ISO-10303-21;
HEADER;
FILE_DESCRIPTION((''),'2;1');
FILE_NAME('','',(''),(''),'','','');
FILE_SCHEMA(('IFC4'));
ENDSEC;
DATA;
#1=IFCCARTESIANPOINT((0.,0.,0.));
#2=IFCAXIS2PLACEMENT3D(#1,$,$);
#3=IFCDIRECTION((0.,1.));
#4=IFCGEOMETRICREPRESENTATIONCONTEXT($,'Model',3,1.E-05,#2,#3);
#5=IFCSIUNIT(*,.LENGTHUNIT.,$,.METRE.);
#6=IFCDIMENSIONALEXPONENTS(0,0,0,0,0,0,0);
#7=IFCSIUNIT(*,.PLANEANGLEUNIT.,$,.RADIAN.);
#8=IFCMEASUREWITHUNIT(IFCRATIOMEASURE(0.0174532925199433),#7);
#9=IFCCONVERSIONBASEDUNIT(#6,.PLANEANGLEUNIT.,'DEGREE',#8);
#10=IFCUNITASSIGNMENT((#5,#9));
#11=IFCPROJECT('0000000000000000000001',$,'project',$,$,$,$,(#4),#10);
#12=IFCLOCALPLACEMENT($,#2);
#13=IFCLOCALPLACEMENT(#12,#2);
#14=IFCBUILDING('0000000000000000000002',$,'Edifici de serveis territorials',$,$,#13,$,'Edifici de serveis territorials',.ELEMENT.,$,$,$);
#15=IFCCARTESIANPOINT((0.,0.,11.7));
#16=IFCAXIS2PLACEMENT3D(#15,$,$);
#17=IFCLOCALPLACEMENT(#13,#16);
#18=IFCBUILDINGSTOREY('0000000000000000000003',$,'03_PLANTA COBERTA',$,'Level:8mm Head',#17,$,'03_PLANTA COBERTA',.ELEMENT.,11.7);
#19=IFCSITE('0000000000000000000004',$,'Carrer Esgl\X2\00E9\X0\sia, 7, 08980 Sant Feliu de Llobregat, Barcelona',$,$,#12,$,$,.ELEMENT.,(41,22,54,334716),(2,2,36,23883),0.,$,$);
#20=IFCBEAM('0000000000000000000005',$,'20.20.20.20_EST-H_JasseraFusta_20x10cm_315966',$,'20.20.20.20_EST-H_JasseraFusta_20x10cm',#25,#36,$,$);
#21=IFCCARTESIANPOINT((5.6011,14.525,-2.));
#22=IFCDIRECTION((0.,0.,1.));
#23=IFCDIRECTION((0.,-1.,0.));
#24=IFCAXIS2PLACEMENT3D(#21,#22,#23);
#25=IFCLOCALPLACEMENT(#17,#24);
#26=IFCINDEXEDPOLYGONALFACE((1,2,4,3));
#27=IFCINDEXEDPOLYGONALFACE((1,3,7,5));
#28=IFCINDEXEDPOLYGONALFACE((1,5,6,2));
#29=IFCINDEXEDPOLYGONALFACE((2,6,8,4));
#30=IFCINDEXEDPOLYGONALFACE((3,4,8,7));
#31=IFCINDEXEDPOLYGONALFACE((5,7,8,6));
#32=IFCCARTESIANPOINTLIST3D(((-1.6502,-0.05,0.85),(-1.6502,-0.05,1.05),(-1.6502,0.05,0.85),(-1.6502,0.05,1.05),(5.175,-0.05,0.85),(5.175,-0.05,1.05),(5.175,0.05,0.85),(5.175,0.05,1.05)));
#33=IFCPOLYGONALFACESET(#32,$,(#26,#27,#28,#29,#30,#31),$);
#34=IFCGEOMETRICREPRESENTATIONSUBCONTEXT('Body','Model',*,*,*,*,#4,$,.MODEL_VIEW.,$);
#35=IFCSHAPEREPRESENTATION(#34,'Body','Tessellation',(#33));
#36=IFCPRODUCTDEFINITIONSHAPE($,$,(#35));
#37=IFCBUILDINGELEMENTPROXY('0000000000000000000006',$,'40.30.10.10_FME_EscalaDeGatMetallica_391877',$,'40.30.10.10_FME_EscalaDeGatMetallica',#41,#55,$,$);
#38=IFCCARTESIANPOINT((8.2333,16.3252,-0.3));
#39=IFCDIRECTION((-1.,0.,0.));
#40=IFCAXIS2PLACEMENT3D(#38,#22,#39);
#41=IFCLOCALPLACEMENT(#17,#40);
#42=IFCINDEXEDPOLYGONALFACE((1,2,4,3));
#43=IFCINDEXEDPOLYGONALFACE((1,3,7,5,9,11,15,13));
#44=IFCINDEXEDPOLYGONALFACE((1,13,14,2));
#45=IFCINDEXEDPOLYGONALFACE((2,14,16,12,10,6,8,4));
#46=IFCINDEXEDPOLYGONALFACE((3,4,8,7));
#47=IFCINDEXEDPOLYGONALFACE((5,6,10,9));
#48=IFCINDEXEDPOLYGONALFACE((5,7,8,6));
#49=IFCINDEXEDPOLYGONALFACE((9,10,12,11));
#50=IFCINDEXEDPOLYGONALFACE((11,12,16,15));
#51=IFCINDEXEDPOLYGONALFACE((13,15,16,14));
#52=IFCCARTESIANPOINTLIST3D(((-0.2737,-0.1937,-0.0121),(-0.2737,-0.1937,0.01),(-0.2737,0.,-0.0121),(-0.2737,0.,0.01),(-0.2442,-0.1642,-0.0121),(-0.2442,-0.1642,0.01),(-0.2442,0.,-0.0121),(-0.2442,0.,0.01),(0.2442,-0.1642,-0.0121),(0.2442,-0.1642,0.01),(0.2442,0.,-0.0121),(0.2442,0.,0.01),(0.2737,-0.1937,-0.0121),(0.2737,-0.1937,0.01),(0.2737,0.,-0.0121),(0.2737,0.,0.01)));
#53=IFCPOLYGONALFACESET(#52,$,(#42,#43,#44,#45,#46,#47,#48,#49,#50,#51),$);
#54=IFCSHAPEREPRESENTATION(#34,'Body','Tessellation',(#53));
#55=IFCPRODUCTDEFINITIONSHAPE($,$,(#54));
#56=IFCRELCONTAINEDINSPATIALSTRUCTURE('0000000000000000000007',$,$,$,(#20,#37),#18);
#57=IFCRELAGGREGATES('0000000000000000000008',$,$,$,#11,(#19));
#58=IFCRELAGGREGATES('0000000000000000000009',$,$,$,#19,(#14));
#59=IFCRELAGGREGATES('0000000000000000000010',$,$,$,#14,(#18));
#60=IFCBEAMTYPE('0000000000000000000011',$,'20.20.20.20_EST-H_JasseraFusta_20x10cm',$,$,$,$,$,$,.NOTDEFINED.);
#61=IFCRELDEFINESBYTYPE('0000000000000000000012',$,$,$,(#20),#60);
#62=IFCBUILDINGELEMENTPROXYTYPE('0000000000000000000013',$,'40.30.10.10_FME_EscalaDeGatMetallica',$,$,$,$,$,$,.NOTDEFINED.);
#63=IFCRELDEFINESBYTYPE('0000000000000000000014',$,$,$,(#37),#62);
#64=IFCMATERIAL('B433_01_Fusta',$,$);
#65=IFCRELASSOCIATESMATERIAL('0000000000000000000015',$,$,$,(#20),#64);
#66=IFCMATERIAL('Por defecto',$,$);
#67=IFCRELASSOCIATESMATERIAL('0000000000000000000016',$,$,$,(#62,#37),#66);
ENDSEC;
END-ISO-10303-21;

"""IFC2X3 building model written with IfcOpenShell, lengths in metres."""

from ifc_helpers import new_model, entity, si_unit, converted_unit, direction, frame, frame_2d, origin, place, context, subcontext, project, spatial, polyline, rectangle, outline, extrude, source, transform, mapped, material, type_object, type_shapes, element, save


model = new_model("IFC2X3")

# Units and contexts
model_context = context("Model", 3, precision=1e-05, world=origin(), true_north=direction((0.0, 1.0)))
body_context = subcontext(model_context, "Body", "Model", "MODEL_VIEW")
ifc_project = project(units=[si_unit("LENGTHUNIT", "METRE"), converted_unit("PLANEANGLEUNIT", "DEGREE", entity("IfcRatioMeasure", 0.0174532925199433), si_unit("PLANEANGLEUNIT", "RADIAN"), dimensions=[0, 0, 0, 0, 0, 0, 0])], contexts=[model_context])

# Site, building, storey
site_placement = place(None, origin())
site = spatial("IfcSite", under=ifc_project, at=site_placement, Name="Carrer Església, 7, 08980 Sant Feliu de Llobregat, Barcelona", CompositionType="ELEMENT", RefLatitude=(41, 22, 54, 334716), RefLongitude=(2, 2, 36, 23883), RefElevation=0.0)
building_placement = place(site_placement, origin())
building = spatial("IfcBuilding", under=site, at=building_placement, Name="Edifici de serveis territorials", LongName="Edifici de serveis territorials", CompositionType="ELEMENT")
storey_placement = place(building_placement, frame((0.0, 0.0, 11.7)))
storey = spatial("IfcBuildingStorey", under=building, at=storey_placement, Name="03_PLANTA COBERTA", ObjectType="Level:8mm Head", LongName="03_PLANTA COBERTA", CompositionType="ELEMENT", Elevation=11.7)

# Beam
ifc_material_1 = material(Name="B433_01_Fusta")
beam_type = type_object("IfcBeamType", Name="20.20.20.20_EST-H_JasseraFusta_20x10cm", PredefinedType="NOTDEFINED")
beam_1_placement = place(storey_placement, frame((5.6011, 14.525, -2.0), z_axis=(0.0, 0.0, 1.0), x_axis=(0.0, -1.0, 0.0)))
element("IfcBeam", 1, at=beam_1_placement, inside=storey, type_object=beam_type, material=ifc_material_1, Name="20.20.20.20_EST-H_JasseraFusta_20x10cm_315966", ObjectType="20.20.20.20_EST-H_JasseraFusta_20x10cm", context=body_context, shape_type="SweptSolid", body=[
    extrude(rectangle(XDim=0.2, YDim=0.1, at=frame_2d((0.0, 0.0), x_axis=(1.0, 0.0))), frame((-1.6502, 0.0, 0.95), z_axis=(1.0, 0.0, 0.0), x_axis=(0.0, 0.0, -1.0)), (0.0, 0.0, 1.0), 6.8252),
])

# Building element proxy
ifc_material_2 = material(Name="Por defecto")
building_element_proxy_type = type_object("IfcBuildingElementProxyType", Name="40.30.10.10_FME_EscalaDeGatMetallica", PredefinedType="NOTDEFINED", material=ifc_material_2)
shared_shape_1 = source(origin(), body_context, "Body", "SweptSolid", [
    extrude(outline(polyline([(-0.0895, -0.2737), (0.1042, -0.2737), (0.1042, 0.2737), (-0.0895, 0.2737), (-0.0895, 0.2442), (0.0747, 0.2442), (0.0747, -0.2442), (-0.0895, -0.2442), (-0.0895, -0.2737)])), frame((0.0, -0.0895, -0.0121), z_axis=(0.0, 0.0, 1.0), x_axis=(0.0, -1.0, 0.0)), (0.0, 0.0, 1.0), 0.0221),
])
type_shapes(building_element_proxy_type, [shared_shape_1])
proxy_placement = place(storey_placement, frame((8.2333, 16.3252, -0.3), z_axis=(0.0, 0.0, 1.0), x_axis=(-1.0, 0.0, 0.0)))
element("IfcBuildingElementProxy", 2, at=proxy_placement, inside=storey, type_object=building_element_proxy_type, material=ifc_material_2, Name="40.30.10.10_FME_EscalaDeGatMetallica_391877", ObjectType="40.30.10.10_FME_EscalaDeGatMetallica", context=body_context, shape_type="MappedRepresentation", body=[
    mapped(shared_shape_1, transform((0.0, 0.0, 0.0), scale=1.0)),
])

save(model, "model.ifc")
